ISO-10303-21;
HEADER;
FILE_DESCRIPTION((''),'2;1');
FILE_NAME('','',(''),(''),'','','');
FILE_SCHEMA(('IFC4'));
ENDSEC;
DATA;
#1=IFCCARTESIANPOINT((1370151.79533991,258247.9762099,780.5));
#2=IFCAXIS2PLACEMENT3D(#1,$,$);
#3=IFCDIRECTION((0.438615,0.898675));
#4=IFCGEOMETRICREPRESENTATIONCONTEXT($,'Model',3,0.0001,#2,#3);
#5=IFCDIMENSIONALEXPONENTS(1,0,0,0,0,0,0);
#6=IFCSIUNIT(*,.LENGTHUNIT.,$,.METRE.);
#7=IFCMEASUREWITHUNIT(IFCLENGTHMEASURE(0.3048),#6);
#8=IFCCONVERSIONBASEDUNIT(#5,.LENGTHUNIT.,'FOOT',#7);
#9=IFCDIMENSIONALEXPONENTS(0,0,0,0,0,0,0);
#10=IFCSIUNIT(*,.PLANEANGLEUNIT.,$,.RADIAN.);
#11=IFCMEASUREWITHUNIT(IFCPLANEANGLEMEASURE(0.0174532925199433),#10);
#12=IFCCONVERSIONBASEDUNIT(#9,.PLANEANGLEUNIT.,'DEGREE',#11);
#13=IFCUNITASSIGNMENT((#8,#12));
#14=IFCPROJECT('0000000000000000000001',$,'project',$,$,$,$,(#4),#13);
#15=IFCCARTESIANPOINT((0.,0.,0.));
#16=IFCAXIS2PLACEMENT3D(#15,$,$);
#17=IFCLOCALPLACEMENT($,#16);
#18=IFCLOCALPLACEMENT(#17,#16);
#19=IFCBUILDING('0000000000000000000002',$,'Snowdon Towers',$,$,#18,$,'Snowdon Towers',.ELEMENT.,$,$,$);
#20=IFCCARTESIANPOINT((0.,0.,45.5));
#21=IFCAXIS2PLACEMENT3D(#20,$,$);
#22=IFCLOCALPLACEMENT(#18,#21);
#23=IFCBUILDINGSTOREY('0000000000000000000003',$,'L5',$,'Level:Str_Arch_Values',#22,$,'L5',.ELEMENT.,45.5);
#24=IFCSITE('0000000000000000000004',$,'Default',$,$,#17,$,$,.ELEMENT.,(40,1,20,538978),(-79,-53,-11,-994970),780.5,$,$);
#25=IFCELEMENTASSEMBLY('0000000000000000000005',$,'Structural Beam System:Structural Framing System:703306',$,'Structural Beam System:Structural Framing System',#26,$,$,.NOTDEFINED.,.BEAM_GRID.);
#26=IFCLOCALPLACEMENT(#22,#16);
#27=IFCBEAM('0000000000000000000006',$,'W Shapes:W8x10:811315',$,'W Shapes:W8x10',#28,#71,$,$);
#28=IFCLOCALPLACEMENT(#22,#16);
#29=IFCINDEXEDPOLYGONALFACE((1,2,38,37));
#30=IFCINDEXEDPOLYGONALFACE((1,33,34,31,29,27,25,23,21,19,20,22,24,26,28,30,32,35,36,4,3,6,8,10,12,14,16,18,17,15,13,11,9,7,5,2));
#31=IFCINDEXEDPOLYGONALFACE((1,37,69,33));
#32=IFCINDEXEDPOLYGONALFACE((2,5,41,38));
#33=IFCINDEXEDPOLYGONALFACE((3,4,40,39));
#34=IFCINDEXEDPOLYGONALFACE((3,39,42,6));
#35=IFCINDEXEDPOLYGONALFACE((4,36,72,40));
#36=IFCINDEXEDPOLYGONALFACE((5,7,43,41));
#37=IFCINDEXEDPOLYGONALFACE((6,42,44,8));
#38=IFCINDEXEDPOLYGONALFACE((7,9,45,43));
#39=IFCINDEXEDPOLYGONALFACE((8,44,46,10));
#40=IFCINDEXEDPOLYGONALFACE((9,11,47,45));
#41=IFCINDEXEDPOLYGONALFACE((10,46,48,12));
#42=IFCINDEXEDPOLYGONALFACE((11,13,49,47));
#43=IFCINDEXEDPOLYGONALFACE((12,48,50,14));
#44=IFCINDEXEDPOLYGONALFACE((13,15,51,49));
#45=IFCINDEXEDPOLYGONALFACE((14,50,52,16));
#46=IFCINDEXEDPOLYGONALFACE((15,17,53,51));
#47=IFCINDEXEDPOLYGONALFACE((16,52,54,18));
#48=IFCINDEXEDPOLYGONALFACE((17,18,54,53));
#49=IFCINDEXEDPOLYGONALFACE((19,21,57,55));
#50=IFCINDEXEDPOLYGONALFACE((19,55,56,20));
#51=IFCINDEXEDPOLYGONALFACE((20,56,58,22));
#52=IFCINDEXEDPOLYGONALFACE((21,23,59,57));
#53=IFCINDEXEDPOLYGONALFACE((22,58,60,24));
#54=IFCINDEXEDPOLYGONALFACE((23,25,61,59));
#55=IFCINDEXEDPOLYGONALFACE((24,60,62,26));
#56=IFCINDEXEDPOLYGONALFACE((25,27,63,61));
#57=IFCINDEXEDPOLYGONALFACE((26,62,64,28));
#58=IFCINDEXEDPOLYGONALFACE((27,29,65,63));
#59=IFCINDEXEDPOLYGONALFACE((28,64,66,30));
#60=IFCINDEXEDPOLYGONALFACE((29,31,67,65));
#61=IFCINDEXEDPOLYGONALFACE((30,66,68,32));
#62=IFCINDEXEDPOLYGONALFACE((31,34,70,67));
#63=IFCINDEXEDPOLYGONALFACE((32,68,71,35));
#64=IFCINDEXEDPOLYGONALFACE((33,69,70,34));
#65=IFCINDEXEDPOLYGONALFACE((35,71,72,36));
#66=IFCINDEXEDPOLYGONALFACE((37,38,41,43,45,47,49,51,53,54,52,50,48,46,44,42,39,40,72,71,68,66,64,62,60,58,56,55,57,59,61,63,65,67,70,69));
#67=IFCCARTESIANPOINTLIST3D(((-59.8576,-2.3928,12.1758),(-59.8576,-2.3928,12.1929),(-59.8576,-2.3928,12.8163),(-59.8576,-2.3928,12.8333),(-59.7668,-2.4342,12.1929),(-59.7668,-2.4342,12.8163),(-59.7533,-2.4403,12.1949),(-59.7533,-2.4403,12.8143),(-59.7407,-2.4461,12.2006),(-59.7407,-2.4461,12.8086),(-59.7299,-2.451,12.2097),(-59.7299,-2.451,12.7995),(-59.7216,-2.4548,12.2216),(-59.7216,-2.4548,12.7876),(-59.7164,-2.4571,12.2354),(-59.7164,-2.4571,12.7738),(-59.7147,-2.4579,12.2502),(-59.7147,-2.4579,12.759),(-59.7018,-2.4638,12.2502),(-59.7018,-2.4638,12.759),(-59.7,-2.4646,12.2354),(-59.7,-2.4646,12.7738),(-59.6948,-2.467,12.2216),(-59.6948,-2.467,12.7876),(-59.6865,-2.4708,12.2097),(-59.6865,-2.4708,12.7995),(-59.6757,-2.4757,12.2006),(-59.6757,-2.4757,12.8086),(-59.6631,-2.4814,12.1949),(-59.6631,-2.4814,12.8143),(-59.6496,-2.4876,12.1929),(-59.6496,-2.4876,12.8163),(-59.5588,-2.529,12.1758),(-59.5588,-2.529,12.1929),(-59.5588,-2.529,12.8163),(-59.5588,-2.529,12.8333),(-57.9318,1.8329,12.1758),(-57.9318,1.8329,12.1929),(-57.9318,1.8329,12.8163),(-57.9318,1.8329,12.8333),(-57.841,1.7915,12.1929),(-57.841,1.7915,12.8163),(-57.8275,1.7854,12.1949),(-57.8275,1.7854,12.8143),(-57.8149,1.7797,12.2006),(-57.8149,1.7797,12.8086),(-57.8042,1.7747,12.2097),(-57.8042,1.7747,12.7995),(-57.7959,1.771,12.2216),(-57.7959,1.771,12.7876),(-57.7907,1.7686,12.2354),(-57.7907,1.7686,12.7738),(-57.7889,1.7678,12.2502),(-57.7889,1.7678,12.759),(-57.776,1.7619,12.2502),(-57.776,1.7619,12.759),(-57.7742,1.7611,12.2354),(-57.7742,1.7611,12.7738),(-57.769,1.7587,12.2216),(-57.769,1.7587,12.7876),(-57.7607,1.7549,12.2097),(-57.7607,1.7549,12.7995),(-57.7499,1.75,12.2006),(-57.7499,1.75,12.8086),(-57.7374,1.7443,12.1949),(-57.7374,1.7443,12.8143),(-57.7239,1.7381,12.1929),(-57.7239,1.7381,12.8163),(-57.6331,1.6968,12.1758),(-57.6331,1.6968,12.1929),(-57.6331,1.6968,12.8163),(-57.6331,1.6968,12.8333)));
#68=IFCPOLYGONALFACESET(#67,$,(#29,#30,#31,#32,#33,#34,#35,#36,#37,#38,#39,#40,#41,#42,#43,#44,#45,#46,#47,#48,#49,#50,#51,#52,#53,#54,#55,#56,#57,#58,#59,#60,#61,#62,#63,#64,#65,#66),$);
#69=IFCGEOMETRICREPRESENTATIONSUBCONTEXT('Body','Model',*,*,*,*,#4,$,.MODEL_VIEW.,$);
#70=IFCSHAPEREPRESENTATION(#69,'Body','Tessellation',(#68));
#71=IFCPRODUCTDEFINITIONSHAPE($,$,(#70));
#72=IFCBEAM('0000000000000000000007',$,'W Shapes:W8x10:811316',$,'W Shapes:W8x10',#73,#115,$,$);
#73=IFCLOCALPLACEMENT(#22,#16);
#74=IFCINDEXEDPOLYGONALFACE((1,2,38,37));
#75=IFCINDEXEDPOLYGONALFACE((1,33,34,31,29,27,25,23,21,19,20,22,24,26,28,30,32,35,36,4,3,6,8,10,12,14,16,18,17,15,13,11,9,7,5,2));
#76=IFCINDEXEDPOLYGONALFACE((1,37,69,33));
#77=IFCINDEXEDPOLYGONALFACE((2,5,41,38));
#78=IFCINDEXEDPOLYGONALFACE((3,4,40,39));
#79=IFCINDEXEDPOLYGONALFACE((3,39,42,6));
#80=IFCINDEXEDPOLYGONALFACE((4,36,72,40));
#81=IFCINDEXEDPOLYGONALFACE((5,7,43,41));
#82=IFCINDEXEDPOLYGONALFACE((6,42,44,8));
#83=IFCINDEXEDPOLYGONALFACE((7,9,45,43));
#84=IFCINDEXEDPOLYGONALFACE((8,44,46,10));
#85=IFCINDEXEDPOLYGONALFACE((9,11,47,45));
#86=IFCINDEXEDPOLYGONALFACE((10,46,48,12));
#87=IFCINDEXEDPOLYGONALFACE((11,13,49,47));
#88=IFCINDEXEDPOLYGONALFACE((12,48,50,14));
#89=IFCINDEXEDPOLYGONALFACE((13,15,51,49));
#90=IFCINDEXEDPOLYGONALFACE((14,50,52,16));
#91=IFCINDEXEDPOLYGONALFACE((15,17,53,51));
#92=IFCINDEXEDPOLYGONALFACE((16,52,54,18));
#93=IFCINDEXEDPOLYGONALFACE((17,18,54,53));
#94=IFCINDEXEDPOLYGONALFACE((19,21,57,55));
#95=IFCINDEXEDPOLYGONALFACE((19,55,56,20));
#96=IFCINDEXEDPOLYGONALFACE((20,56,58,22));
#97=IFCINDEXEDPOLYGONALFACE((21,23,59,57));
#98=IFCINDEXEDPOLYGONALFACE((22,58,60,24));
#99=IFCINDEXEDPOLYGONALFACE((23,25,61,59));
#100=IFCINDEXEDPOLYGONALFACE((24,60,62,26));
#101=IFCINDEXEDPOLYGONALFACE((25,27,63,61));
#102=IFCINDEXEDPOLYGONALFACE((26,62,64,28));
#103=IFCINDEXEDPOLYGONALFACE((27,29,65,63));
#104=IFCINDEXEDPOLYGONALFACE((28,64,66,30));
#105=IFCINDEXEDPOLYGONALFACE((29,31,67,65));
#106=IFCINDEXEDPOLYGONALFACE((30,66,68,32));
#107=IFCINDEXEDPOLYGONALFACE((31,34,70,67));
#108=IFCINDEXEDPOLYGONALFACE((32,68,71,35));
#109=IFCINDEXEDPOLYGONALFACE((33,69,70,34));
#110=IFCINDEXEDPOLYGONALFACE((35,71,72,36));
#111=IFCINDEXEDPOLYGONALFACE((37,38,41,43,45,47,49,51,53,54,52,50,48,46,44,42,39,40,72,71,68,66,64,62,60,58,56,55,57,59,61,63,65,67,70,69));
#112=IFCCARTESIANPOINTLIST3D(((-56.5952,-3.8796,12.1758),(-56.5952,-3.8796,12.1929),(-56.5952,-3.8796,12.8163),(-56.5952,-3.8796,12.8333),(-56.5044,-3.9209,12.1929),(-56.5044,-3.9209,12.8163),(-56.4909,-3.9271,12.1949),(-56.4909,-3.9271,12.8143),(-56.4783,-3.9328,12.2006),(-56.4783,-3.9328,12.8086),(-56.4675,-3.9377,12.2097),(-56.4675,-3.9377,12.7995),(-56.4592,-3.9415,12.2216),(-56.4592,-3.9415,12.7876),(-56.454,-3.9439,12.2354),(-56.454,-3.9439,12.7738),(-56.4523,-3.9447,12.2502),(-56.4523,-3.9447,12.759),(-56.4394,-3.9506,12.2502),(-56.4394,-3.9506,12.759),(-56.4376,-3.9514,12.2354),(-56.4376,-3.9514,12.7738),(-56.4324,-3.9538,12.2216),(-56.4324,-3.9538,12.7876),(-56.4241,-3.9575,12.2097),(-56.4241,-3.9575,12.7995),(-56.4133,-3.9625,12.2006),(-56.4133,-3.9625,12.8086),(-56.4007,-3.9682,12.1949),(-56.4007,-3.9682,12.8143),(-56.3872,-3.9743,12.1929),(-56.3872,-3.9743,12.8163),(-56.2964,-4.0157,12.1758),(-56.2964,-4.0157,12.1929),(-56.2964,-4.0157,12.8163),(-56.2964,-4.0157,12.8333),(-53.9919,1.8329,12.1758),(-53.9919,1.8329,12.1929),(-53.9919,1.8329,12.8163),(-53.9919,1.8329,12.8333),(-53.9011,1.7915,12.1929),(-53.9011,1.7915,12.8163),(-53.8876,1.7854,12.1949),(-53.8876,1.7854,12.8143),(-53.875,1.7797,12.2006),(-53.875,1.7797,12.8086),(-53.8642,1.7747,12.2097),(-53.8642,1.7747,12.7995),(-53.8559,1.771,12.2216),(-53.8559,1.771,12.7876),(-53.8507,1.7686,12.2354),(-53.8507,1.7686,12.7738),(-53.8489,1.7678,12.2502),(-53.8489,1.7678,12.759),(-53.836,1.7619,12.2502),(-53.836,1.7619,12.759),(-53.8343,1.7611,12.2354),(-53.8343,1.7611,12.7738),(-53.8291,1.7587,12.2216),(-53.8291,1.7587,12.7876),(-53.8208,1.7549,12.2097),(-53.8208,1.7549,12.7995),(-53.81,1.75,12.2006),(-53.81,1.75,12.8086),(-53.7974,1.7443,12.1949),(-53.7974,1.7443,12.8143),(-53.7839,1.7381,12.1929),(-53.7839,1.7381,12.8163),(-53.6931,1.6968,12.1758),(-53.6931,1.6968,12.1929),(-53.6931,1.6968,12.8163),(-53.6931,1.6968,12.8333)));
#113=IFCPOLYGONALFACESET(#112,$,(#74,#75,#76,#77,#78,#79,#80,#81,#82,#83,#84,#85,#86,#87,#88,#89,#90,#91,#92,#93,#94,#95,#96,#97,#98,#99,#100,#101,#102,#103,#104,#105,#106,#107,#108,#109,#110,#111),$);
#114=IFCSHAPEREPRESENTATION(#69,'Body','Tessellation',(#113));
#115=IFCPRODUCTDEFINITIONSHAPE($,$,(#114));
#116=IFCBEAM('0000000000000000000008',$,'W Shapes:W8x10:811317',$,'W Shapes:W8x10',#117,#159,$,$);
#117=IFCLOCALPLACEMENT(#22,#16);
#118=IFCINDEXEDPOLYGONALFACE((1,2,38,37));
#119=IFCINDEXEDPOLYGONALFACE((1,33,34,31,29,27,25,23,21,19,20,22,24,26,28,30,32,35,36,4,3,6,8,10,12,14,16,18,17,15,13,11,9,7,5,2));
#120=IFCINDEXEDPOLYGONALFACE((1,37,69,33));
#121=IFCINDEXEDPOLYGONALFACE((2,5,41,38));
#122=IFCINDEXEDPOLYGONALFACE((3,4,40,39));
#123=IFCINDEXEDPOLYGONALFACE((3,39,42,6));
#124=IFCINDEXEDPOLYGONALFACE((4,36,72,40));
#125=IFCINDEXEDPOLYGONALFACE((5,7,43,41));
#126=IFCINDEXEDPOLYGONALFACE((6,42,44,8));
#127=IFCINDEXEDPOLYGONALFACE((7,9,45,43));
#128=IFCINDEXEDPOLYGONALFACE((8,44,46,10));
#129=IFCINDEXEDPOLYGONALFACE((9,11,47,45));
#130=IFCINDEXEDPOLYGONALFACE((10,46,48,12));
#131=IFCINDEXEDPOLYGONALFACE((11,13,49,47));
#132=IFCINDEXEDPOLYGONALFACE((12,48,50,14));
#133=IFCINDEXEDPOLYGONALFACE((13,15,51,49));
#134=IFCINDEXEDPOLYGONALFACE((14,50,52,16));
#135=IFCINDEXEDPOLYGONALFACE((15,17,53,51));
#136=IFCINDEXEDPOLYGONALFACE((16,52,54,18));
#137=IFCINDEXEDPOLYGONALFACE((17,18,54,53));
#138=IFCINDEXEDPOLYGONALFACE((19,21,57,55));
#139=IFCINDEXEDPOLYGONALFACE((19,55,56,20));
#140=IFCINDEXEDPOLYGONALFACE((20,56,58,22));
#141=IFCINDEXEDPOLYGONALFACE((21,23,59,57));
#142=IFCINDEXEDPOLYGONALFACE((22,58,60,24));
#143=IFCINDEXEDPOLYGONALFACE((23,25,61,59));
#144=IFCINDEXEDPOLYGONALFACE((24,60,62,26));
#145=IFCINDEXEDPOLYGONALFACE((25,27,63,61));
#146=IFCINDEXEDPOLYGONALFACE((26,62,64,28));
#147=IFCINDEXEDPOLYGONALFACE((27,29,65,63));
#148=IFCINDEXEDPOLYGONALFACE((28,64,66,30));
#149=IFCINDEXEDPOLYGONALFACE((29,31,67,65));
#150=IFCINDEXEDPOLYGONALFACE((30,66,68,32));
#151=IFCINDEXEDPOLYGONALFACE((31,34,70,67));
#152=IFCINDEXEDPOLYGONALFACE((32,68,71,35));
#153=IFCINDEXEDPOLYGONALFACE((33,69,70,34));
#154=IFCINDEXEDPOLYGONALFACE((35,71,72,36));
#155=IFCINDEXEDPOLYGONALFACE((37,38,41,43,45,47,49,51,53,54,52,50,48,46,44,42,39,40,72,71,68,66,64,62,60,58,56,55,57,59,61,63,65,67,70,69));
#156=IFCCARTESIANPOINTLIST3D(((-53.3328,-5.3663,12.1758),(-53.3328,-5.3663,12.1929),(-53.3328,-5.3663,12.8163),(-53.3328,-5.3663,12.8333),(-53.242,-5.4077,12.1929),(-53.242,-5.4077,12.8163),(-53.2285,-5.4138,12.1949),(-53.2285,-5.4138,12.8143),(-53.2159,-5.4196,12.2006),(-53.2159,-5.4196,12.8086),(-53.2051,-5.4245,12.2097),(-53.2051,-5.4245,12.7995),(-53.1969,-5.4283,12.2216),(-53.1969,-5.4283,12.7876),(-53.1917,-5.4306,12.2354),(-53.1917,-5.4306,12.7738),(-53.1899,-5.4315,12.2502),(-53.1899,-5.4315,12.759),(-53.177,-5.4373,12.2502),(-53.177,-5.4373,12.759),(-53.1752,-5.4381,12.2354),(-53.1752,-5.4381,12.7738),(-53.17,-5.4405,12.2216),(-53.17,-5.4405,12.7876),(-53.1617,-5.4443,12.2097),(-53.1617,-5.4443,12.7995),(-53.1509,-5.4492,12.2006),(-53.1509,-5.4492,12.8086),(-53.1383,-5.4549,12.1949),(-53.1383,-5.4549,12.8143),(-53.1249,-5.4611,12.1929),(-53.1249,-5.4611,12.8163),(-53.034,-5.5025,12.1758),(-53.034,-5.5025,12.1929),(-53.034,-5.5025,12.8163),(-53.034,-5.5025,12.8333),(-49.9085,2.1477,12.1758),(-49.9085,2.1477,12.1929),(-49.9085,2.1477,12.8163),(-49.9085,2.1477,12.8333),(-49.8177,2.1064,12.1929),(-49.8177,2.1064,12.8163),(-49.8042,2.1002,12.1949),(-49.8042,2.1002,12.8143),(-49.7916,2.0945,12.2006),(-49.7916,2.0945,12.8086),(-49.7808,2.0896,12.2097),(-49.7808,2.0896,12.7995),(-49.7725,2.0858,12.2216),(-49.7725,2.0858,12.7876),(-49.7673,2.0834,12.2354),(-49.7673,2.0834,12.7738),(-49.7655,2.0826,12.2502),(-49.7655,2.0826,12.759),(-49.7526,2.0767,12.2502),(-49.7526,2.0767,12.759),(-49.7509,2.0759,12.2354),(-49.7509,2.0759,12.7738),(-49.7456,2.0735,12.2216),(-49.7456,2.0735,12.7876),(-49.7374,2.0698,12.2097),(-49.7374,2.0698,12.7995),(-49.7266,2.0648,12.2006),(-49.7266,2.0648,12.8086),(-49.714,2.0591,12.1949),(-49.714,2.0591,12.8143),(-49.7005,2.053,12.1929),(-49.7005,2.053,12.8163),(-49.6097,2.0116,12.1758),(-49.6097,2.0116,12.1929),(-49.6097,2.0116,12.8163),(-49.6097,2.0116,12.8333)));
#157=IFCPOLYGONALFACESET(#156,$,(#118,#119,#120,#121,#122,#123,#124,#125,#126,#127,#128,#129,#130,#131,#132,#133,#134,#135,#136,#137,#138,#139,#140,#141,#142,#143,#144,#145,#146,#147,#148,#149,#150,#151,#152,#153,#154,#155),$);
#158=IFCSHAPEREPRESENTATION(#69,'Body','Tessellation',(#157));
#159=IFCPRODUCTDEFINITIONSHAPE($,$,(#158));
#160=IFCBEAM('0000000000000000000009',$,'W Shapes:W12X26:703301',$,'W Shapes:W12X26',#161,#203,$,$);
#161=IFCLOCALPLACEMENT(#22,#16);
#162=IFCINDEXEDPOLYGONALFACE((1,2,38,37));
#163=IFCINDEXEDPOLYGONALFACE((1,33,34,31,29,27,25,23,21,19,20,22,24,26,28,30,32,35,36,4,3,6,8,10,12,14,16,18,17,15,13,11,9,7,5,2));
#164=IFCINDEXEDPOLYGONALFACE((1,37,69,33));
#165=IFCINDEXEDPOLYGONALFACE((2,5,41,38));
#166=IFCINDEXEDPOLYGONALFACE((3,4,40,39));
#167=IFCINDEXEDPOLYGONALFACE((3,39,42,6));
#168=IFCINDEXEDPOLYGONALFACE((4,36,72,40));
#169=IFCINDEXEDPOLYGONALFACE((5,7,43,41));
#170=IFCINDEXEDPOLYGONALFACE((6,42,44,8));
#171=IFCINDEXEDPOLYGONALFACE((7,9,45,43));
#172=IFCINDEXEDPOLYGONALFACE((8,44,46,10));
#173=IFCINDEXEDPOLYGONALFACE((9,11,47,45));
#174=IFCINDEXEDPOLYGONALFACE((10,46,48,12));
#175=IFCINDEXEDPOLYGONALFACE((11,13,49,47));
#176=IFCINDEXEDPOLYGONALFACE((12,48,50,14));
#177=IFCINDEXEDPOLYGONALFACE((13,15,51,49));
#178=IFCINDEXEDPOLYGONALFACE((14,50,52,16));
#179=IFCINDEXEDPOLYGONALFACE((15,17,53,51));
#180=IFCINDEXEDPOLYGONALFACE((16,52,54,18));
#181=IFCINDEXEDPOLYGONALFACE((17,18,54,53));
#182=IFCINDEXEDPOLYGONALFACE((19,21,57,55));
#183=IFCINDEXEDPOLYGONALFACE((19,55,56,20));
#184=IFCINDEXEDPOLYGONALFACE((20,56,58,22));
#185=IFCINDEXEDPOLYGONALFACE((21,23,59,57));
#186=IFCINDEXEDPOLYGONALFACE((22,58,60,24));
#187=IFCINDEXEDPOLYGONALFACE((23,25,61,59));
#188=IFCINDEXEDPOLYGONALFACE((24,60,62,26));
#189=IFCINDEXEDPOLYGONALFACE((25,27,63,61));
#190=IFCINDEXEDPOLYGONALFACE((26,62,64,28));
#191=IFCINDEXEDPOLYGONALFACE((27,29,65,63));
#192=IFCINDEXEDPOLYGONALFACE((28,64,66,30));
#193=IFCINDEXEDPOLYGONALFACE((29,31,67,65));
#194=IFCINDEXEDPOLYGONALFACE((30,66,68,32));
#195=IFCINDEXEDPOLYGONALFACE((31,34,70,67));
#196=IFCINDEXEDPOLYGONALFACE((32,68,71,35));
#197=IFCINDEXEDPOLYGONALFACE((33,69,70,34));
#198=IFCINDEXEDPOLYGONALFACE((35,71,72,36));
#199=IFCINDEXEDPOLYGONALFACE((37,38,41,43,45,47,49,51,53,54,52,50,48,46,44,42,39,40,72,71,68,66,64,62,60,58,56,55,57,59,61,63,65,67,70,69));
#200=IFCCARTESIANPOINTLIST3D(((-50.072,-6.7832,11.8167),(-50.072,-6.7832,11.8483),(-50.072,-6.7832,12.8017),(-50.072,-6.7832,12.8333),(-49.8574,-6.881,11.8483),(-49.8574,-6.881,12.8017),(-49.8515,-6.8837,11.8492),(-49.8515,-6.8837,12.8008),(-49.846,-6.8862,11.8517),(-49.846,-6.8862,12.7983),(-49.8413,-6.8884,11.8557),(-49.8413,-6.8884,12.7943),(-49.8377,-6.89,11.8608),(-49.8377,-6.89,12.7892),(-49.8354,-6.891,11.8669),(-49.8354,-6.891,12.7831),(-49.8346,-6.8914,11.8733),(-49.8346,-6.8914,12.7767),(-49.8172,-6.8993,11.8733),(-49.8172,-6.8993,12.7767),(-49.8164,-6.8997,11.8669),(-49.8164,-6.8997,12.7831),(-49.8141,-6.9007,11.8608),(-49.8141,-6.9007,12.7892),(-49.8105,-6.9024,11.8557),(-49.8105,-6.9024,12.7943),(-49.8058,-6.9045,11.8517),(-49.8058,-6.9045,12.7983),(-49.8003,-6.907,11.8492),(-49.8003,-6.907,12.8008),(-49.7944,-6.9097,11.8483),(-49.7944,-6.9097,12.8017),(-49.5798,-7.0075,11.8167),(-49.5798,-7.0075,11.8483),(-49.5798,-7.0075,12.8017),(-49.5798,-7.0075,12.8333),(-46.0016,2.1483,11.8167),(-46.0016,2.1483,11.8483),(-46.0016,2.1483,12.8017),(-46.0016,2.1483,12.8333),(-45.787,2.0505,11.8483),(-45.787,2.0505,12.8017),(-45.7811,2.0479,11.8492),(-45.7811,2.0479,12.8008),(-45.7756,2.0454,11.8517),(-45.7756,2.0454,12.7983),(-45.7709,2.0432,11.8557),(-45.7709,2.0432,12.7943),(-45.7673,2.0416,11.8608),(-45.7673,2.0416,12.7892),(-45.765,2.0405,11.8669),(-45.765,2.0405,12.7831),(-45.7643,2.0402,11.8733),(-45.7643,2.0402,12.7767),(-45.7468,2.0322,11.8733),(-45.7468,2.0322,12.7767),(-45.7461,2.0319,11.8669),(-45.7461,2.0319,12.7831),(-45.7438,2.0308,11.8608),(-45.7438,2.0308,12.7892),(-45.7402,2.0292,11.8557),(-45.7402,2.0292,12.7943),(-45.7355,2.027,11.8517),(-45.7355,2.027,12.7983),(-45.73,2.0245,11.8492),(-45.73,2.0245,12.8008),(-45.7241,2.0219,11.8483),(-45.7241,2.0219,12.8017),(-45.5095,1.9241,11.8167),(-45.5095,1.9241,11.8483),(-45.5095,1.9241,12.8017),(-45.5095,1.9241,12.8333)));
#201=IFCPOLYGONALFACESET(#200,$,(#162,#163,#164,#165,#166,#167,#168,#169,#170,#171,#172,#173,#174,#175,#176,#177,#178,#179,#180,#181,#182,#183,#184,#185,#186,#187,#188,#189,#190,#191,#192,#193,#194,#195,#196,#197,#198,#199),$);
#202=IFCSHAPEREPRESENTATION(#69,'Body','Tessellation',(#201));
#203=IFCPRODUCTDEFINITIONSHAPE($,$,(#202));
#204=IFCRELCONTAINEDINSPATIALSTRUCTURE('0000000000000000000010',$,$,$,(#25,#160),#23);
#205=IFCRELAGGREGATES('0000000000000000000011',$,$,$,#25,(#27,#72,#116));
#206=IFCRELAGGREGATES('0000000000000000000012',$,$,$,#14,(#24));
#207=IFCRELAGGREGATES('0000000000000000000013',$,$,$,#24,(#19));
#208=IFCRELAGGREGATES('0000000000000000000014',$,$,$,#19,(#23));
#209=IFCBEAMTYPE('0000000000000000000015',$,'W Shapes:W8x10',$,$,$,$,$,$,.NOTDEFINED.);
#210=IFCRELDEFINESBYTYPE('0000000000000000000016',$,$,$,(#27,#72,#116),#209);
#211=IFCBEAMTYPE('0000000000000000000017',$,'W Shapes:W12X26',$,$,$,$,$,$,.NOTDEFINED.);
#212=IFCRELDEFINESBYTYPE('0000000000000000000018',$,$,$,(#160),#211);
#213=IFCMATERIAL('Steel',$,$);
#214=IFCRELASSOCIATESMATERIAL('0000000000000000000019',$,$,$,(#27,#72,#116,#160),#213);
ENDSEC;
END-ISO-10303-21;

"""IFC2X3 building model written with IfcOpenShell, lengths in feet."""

from ifc_helpers import new_model, entity, si_unit, converted_unit, direction, frame, frame_2d, origin, place, context, subcontext, project, spatial, i_section, extrude, material, type_object, element, aggregate, save


model = new_model("IFC2X3")

# Units and contexts
model_context = context("Model", 3, precision=0.0001, world=frame((1370151.79533991, 258247.9762099, 780.5)), true_north=direction((0.438615, 0.898675)))
body_context = subcontext(model_context, "Body", "Model", "MODEL_VIEW")
ifc_project = project(units=[converted_unit("LENGTHUNIT", "FOOT", entity("IfcLengthMeasure", 0.3048), si_unit("LENGTHUNIT", "METRE"), dimensions=[1, 0, 0, 0, 0, 0, 0]), converted_unit("PLANEANGLEUNIT", "DEGREE", entity("IfcPlaneAngleMeasure", 0.0174532925199433), si_unit("PLANEANGLEUNIT", "RADIAN"), dimensions=[0, 0, 0, 0, 0, 0, 0])], contexts=[model_context])

# Site, building, storey
site_placement = place(None, origin())
site = spatial("IfcSite", under=ifc_project, at=site_placement, Name="Default", CompositionType="ELEMENT", RefLatitude=(40, 1, 20, 538978), RefLongitude=(-79, -53, -11, -994970), RefElevation=780.5)
building_placement = place(site_placement, origin())
building = spatial("IfcBuilding", under=site, at=building_placement, Name="Snowdon Towers", LongName="Snowdon Towers", CompositionType="ELEMENT")
storey_placement = place(building_placement, frame((0.0, 0.0, 45.5)))
storey = spatial("IfcBuildingStorey", under=building, at=storey_placement, Name="L5", ObjectType="Level:Str_Arch_Values", LongName="L5", CompositionType="ELEMENT", Elevation=45.5)

# Shared definitions
ifc_material_1 = material(Name="Steel")

# Element assembly, beams
beam_type_1 = type_object("IfcBeamType", Name="W Shapes:W8x10", PredefinedType="NOTDEFINED")
assembly_1_placement = place(storey_placement, origin())
assembly_1 = element("IfcElementAssembly", 1, at=assembly_1_placement, inside=storey, Name="Structural Beam System:Structural Framing System:703306", ObjectType="Structural Beam System:Structural Framing System", AssemblyPlace="NOTDEFINED", PredefinedType="BEAM_GRID")
beam_1_placement = place(assembly_1_placement, frame((-59.8376, -2.7449, 12.8333), z_axis=(0.0, 0.0, 1.0), x_axis=(0.414693, 0.909961, 0.0)))
beam_1 = element("IfcBeam", 2, at=beam_1_placement, type_object=beam_type_1, material=ifc_material_1, Name="W Shapes:W8x10:811315", ObjectType="W Shapes:W8x10", context=body_context, shape_type="SweptSolid", body=[
    extrude(i_section(OverallWidth=0.3283, OverallDepth=0.6575, WebThickness=0.0142, FlangeThickness=0.0171, FilletRadius=0.0573, at=frame_2d((0.0, 0.0), x_axis=(0.0, 1.0))), frame((0.3121, 0.0, -0.3288), z_axis=(1.0, 0.0, 0.0), x_axis=(0.0, 0.0, -1.0)), (0.0, 0.0, 1.0), 4.6438),
])
beam_2_placement = place(assembly_1_placement, frame((-56.5752, -4.2316, 12.8333), z_axis=(0.0, 0.0, 1.0), x_axis=(0.414693, 0.909961, 0.0)))
beam_2 = element("IfcBeam", 3, at=beam_2_placement, type_object=beam_type_1, material=ifc_material_1, Name="W Shapes:W8x10:811316", ObjectType="W Shapes:W8x10", context=body_context, shape_type="SweptSolid", body=[
    extrude(i_section(OverallWidth=0.3283, OverallDepth=0.6575, WebThickness=0.0142, FlangeThickness=0.0171, FilletRadius=0.0573, at=frame_2d((0.0, 0.0), x_axis=(0.0, 1.0))), frame((0.3121, 0.0, -0.3288), z_axis=(1.0, 0.0, 0.0), x_axis=(0.0, 0.0, -1.0)), (0.0, 0.0, 1.0), 6.2777),
])
beam_3_placement = place(assembly_1_placement, frame((-53.3128, -5.7184, 12.8333), z_axis=(0.0, 0.0, 1.0), x_axis=(0.414693, 0.909961, 0.0)))
beam_3 = element("IfcBeam", 4, at=beam_3_placement, type_object=beam_type_1, material=ifc_material_1, Name="W Shapes:W8x10:811317", ObjectType="W Shapes:W8x10", context=body_context, shape_type="SweptSolid", body=[
    extrude(i_section(OverallWidth=0.3283, OverallDepth=0.6575, WebThickness=0.0142, FlangeThickness=0.0171, FilletRadius=0.0573, at=frame_2d((0.0, 0.0), x_axis=(0.0, 1.0))), frame((0.3121, 0.0, -0.3288), z_axis=(1.0, 0.0, 0.0), x_axis=(0.0, 0.0, -1.0)), (0.0, 0.0, 1.0), 8.2576),
])
aggregate(assembly_1, [beam_1, beam_2, beam_3])

# Beam
beam_type_2 = type_object("IfcBeamType", Name="W Shapes:W12X26", PredefinedType="NOTDEFINED")
beam_4_placement = place(storey_placement, frame((-49.9814, -7.2366, 12.8333), z_axis=(0.0, 0.0, 1.0), x_axis=(0.414693, 0.909961, 0.0)))
element("IfcBeam", 5, at=beam_4_placement, inside=storey, type_object=beam_type_2, material=ifc_material_1, Name="W Shapes:W12X26:703301", ObjectType="W Shapes:W12X26", context=body_context, shape_type="SweptSolid", body=[
    extrude(i_section(OverallWidth=0.5408, OverallDepth=1.0167, WebThickness=0.0192, FlangeThickness=0.0317, FilletRadius=0.025, at=frame_2d((0.0, 0.0), x_axis=(0.0, 1.0))), frame((0.375, 0.0, -0.5083), z_axis=(1.0, 0.0, 0.0), x_axis=(0.0, 0.0, -1.0)), (0.0, 0.0, 1.0), 9.8153),
])

save(model, "model.ifc")
